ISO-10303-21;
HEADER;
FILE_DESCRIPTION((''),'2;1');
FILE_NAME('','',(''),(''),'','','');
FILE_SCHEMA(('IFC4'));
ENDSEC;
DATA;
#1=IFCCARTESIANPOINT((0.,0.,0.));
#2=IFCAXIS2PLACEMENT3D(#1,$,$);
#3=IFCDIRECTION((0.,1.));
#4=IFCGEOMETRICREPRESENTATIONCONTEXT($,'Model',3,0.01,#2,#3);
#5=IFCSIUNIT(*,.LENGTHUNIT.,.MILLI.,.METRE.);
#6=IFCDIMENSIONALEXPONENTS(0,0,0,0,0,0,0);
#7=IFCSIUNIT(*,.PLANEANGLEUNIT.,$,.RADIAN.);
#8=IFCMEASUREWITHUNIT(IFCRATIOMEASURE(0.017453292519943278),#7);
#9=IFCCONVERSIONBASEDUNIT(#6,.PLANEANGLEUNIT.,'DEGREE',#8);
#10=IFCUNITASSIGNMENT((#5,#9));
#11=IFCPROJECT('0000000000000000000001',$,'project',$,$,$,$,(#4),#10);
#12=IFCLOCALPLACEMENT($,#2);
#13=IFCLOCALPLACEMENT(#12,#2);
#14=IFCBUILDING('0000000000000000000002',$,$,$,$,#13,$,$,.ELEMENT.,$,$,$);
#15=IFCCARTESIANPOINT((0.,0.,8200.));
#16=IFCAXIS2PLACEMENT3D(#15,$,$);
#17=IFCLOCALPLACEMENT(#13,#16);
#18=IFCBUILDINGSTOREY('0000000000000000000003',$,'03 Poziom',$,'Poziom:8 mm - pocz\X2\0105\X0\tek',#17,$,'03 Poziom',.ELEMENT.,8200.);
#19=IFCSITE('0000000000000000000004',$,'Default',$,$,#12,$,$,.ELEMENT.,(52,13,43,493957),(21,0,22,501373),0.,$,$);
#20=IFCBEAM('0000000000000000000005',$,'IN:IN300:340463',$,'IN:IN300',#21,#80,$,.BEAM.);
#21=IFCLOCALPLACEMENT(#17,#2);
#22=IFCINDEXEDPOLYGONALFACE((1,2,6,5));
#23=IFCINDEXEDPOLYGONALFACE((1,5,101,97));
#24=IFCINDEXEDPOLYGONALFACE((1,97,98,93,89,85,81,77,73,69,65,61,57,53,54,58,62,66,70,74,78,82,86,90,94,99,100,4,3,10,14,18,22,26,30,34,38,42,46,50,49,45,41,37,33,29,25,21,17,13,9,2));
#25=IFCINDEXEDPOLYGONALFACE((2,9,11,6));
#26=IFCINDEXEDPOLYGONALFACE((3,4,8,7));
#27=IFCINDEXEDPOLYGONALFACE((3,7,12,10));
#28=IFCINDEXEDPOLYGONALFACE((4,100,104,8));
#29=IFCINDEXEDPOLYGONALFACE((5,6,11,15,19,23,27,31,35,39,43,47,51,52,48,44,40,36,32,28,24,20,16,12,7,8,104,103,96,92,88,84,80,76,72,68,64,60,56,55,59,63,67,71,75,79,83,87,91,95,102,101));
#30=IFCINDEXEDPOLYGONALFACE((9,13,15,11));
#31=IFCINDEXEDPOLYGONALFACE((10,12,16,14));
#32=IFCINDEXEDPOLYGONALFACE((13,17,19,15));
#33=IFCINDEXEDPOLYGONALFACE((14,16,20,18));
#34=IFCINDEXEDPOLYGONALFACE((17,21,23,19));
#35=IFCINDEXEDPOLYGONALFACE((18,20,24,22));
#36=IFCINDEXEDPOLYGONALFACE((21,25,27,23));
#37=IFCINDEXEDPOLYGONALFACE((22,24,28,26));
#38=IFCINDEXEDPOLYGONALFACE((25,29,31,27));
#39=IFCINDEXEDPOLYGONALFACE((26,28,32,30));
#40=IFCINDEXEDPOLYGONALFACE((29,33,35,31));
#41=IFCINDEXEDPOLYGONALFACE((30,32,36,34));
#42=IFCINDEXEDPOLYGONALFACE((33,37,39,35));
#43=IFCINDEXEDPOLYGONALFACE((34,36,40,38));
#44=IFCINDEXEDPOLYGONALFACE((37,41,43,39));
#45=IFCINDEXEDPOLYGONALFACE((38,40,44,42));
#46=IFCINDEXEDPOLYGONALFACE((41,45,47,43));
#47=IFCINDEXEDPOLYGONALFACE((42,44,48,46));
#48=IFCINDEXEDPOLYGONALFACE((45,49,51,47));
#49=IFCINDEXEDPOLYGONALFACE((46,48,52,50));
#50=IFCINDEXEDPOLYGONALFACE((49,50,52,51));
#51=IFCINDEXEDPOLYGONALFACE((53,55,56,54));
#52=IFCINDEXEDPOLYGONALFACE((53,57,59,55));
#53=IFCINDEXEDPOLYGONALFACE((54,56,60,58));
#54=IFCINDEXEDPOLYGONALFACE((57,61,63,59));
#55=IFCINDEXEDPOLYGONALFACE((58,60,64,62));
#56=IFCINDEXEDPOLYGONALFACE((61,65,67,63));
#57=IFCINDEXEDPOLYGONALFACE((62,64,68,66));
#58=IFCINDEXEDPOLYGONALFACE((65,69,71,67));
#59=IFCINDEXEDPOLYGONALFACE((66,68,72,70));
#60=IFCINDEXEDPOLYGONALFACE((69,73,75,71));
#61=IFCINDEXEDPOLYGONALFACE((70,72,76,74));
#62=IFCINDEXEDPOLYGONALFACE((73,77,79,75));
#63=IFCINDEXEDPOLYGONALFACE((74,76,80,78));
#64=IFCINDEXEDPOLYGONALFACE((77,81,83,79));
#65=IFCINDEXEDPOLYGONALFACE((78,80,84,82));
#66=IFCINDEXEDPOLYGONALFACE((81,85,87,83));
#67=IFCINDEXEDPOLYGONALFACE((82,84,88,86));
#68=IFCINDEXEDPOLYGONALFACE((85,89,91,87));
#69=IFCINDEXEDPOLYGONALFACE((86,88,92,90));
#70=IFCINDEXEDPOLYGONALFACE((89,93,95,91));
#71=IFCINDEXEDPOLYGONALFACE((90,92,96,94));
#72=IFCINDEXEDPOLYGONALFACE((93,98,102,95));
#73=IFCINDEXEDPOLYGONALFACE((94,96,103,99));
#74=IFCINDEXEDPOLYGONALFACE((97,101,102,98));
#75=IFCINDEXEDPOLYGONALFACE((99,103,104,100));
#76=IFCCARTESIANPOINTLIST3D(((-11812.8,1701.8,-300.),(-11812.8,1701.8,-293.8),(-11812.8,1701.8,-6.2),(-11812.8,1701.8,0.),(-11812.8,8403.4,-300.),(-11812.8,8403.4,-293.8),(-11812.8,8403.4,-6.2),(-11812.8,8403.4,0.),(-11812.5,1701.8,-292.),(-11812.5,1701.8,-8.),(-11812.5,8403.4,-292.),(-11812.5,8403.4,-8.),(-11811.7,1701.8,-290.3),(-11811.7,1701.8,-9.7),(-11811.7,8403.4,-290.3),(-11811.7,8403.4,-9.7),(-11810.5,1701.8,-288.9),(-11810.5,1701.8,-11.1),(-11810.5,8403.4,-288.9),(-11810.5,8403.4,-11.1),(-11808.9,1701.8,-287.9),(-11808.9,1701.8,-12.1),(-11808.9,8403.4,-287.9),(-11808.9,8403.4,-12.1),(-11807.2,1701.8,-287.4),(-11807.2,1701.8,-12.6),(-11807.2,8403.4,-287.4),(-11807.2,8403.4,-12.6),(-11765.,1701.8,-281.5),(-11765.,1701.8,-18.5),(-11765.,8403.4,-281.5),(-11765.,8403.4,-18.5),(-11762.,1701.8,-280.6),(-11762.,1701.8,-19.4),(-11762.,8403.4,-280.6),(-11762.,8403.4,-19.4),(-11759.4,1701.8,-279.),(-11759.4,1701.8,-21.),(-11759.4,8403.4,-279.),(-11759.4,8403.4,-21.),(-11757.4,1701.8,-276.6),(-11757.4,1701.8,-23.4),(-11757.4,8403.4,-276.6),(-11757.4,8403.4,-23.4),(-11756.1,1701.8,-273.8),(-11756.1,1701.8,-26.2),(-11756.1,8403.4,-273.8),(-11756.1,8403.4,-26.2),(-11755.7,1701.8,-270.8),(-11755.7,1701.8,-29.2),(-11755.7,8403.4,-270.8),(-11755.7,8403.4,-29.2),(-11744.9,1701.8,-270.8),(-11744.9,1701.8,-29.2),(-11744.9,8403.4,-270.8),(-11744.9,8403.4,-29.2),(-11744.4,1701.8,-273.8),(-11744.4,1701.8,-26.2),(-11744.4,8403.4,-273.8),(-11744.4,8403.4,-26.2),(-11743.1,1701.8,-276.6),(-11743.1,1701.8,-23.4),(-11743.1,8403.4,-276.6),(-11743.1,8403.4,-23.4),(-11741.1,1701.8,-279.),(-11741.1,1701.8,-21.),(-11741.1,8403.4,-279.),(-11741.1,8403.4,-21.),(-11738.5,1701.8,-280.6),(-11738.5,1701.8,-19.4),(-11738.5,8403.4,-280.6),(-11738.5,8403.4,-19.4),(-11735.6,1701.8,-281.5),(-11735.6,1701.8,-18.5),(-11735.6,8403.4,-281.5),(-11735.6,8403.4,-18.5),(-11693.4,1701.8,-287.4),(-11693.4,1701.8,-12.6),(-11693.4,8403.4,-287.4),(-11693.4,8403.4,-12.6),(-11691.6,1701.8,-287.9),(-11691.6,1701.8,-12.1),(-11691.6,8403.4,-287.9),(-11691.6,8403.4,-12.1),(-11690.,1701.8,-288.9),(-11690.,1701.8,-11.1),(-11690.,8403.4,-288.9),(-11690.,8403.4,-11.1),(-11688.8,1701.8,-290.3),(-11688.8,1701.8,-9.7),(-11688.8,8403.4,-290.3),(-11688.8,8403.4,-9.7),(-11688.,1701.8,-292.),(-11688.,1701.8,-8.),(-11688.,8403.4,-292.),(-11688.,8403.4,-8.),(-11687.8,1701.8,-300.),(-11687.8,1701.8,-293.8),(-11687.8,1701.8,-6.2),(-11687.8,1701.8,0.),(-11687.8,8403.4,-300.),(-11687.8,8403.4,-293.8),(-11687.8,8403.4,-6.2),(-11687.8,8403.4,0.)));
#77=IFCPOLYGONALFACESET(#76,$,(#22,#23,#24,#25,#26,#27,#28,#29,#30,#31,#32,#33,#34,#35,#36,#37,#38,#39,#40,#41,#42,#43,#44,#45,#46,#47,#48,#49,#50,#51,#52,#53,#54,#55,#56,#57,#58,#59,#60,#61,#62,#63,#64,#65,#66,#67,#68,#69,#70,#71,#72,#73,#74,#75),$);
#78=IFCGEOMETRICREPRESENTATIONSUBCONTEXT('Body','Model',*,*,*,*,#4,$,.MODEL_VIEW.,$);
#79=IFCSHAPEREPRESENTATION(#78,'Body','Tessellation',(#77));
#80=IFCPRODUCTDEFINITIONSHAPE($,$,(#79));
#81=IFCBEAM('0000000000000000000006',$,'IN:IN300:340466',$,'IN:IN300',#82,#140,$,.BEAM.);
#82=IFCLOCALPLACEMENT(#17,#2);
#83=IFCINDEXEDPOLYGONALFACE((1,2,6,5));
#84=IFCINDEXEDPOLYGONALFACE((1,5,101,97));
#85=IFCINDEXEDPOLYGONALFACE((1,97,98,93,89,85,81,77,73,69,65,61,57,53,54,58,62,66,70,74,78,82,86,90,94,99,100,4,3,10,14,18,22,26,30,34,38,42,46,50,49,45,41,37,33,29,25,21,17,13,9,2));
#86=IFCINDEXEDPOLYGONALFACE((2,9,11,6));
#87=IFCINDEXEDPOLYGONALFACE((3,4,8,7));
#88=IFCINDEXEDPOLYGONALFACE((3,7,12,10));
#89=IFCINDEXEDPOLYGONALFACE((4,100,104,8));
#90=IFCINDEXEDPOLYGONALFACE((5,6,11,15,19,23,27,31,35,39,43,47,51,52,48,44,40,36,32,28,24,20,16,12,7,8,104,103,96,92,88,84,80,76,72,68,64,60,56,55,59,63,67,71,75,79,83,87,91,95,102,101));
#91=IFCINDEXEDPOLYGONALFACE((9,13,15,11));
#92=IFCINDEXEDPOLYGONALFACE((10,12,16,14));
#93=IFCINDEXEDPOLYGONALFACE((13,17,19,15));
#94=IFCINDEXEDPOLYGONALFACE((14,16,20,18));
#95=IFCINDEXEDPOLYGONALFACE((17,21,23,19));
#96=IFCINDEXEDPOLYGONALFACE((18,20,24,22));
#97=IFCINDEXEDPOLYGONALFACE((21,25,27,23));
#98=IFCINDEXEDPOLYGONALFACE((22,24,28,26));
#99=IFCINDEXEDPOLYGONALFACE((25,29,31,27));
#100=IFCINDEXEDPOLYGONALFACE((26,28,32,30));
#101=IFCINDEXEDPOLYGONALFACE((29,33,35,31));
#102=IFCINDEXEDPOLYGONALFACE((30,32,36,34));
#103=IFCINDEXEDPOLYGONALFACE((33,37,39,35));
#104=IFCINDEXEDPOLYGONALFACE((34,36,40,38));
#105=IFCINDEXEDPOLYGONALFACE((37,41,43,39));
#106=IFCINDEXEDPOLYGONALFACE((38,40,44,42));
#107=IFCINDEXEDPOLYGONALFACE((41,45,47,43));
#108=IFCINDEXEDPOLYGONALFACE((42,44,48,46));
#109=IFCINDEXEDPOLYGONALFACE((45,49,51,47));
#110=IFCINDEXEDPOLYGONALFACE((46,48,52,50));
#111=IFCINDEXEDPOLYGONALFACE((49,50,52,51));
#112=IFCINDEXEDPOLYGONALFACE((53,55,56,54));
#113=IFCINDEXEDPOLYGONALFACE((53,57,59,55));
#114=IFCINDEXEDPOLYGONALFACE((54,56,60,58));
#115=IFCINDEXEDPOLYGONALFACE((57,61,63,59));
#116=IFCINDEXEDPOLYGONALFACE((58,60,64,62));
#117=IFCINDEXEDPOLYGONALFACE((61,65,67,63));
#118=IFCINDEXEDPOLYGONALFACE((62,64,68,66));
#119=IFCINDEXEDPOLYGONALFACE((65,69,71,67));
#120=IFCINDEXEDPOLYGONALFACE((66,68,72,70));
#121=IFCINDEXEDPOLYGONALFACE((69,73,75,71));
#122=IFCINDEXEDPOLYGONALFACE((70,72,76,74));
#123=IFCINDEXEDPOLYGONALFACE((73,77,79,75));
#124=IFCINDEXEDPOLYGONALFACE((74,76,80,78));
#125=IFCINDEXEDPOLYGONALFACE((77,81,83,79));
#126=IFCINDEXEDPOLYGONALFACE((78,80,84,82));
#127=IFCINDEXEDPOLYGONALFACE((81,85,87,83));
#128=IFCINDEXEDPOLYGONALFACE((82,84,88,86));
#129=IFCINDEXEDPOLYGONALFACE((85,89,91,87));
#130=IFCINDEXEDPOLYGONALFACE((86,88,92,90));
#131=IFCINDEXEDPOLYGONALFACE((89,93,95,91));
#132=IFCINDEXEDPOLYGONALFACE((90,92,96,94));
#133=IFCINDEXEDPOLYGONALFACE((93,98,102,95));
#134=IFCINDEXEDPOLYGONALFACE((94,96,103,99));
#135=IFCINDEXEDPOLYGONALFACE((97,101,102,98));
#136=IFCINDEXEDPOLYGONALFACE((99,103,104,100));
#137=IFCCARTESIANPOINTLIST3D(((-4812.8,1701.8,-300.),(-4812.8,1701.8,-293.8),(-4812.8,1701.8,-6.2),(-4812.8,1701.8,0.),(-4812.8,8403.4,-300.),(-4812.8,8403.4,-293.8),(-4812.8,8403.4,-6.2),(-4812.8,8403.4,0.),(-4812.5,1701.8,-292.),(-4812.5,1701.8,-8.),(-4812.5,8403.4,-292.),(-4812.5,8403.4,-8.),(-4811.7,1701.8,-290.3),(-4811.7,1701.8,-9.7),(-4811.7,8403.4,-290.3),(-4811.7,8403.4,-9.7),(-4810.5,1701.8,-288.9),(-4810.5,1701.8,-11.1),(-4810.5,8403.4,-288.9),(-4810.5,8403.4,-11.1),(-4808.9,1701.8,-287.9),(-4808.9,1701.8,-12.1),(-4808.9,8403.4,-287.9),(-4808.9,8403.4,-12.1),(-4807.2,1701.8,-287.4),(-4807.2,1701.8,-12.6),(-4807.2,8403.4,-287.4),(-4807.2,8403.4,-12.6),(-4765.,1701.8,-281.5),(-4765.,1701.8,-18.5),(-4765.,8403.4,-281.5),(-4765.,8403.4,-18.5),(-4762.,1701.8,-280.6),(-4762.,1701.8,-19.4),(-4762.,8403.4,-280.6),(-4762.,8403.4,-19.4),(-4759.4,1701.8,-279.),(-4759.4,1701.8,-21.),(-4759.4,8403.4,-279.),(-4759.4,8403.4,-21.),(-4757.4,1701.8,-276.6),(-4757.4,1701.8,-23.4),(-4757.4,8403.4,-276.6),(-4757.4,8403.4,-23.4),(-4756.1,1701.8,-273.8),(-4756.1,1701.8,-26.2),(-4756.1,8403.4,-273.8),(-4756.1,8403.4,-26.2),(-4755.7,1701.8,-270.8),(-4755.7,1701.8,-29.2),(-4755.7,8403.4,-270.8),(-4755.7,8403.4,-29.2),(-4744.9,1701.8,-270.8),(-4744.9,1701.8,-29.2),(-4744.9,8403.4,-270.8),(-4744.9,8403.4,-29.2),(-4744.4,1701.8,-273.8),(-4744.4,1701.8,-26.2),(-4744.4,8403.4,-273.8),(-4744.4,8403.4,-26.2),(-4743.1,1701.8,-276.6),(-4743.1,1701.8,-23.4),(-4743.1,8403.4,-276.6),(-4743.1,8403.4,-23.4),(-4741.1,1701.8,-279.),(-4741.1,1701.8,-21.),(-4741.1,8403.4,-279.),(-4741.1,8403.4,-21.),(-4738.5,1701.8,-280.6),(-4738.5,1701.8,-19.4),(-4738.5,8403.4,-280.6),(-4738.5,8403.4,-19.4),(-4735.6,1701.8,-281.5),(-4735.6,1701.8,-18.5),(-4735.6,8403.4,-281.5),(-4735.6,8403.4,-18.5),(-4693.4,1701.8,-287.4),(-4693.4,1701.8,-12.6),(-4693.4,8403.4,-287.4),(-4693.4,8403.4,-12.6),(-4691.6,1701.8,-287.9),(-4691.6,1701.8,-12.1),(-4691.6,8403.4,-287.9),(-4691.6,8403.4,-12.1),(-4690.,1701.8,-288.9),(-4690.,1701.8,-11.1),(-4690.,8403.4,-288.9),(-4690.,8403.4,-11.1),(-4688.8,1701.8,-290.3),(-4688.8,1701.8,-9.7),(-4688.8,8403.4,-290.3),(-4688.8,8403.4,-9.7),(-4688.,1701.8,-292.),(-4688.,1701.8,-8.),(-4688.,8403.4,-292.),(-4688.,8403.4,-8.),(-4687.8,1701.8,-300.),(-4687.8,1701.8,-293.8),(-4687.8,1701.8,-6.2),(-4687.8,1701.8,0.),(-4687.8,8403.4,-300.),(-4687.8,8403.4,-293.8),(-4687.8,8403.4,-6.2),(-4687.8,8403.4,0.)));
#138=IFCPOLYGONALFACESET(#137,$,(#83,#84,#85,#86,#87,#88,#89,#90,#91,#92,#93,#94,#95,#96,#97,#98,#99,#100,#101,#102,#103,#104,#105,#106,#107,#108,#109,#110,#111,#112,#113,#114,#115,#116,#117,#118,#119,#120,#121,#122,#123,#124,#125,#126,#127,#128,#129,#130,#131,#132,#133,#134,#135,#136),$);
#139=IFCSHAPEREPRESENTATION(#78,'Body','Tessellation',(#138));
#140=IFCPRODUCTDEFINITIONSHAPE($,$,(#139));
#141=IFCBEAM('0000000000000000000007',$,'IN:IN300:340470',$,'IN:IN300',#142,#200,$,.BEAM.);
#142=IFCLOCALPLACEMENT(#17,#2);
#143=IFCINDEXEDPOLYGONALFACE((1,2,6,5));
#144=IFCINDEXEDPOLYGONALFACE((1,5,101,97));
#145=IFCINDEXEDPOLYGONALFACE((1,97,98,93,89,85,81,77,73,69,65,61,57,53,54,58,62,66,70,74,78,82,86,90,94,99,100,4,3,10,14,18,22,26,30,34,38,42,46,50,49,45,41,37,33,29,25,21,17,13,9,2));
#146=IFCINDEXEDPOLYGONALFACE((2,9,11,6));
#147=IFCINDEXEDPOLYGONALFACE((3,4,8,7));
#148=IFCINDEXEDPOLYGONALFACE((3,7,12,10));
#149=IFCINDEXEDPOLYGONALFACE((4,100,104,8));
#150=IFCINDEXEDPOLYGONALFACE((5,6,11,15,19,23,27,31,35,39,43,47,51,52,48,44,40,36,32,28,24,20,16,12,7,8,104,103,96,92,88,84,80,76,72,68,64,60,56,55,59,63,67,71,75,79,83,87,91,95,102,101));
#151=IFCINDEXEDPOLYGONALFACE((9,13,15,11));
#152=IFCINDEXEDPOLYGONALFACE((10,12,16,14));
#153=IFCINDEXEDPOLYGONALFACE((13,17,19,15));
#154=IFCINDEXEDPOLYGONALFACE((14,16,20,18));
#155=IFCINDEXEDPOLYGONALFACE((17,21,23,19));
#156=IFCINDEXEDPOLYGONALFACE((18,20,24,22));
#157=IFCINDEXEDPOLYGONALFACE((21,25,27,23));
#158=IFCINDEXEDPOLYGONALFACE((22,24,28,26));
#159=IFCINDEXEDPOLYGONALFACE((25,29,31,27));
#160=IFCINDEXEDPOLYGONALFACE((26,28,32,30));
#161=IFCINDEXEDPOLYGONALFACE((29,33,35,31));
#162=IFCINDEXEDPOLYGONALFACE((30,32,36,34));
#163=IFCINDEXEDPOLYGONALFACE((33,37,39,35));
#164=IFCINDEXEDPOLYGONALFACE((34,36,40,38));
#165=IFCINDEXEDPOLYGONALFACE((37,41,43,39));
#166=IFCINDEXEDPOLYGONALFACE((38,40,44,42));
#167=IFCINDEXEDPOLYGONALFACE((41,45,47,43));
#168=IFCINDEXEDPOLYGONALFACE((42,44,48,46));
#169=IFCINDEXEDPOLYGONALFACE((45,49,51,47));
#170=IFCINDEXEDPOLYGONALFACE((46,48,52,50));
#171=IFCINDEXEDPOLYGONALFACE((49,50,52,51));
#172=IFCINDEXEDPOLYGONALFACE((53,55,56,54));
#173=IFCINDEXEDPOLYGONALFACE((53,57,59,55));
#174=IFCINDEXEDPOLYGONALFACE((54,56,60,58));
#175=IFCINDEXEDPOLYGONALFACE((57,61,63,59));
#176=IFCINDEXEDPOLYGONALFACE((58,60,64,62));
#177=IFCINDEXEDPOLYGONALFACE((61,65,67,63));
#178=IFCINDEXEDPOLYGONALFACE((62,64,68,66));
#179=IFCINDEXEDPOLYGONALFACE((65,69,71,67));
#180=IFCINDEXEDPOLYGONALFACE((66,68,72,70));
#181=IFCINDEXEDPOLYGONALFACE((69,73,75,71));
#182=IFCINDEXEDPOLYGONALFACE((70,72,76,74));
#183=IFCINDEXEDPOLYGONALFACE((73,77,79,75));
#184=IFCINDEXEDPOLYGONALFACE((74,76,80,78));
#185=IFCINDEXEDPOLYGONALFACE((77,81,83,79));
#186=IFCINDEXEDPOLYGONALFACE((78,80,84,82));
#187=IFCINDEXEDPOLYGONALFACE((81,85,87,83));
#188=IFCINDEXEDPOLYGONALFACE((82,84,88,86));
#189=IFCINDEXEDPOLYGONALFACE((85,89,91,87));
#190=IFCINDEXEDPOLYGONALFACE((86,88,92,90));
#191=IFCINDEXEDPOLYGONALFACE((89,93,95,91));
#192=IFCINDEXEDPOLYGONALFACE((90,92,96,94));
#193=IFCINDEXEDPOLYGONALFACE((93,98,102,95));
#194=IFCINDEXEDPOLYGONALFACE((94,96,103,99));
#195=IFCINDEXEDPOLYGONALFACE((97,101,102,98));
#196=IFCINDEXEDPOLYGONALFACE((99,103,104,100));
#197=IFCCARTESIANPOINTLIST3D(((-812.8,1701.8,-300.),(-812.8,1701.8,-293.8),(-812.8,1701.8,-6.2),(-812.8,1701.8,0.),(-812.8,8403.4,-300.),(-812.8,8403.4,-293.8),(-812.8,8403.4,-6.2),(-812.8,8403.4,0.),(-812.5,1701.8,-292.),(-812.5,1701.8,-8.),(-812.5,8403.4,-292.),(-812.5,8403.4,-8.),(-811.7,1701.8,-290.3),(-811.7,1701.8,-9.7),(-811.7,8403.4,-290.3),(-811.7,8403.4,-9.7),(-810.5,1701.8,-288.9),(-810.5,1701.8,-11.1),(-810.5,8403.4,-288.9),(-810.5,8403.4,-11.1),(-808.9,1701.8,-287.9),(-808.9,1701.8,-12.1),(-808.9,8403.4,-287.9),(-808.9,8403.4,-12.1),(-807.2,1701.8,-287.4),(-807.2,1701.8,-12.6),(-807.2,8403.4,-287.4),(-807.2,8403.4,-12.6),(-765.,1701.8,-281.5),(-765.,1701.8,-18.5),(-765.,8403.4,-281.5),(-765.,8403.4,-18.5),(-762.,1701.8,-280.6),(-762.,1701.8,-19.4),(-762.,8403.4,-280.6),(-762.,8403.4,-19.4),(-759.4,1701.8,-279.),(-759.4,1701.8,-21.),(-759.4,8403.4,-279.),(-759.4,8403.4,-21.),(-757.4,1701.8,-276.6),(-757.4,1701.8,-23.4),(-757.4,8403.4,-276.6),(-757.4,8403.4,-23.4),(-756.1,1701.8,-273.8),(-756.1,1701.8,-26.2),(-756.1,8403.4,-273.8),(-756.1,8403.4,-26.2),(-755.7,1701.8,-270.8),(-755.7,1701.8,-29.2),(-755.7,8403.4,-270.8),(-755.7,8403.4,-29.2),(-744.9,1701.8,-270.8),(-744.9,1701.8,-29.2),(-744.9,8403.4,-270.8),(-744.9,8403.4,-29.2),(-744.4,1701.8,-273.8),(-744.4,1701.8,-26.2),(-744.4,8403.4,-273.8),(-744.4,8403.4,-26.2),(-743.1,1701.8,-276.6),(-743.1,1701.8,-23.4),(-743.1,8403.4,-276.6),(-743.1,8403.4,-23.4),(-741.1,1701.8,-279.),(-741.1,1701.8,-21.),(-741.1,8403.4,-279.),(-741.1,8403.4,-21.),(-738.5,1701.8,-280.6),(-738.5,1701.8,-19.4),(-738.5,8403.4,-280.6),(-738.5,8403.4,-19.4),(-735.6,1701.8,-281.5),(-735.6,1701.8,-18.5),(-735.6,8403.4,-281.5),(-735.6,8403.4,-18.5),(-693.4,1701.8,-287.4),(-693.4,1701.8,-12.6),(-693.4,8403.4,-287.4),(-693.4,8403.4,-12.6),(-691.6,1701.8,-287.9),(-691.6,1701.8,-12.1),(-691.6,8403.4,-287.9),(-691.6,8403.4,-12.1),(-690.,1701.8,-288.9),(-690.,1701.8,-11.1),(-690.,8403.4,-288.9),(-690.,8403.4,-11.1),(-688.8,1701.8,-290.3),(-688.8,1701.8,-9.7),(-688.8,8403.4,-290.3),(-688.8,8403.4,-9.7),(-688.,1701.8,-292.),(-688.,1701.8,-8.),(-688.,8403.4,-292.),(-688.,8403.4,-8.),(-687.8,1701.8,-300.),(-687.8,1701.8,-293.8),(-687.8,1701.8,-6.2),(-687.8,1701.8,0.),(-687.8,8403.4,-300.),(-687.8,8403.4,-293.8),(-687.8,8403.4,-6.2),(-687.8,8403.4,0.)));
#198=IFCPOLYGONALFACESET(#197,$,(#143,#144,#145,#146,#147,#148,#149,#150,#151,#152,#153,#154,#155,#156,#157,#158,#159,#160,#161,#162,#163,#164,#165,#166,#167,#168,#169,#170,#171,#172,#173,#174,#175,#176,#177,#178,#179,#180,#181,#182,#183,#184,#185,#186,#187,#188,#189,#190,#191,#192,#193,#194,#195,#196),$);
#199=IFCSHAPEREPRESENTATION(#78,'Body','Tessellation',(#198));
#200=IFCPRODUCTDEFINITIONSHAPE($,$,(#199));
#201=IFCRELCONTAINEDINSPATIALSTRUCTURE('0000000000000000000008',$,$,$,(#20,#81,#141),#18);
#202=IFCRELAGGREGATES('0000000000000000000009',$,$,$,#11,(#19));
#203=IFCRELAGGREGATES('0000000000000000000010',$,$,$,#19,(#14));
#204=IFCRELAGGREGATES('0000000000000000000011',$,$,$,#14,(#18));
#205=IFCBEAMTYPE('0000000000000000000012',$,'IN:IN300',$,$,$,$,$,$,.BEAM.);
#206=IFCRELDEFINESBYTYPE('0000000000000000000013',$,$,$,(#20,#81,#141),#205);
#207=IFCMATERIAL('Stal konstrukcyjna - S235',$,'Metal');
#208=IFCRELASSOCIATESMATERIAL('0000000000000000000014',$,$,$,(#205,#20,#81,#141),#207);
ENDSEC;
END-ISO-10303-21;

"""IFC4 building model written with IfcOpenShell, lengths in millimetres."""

from ifc_helpers import new_model, entity, si_unit, converted_unit, direction, frame, origin, place, context, subcontext, project, spatial, line, arc, indexed_curve, outline, extrude, source, transform, mapped, material, type_object, type_shapes, element, save


model = new_model("IFC4")

# Units and contexts
model_context = context("Model", 3, precision=0.01, world=origin(), true_north=direction((0.0, 1.0)))
body_context = subcontext(model_context, "Body", "Model", "MODEL_VIEW")
ifc_project = project(units=[si_unit("LENGTHUNIT", "METRE", prefix="MILLI"), converted_unit("PLANEANGLEUNIT", "DEGREE", entity("IfcRatioMeasure", 0.017453292519943278), si_unit("PLANEANGLEUNIT", "RADIAN"), dimensions=[0, 0, 0, 0, 0, 0, 0])], contexts=[model_context])

# Site, building, storey
site_placement = place(None, origin())
site = spatial("IfcSite", under=ifc_project, at=site_placement, Name="Default", CompositionType="ELEMENT", RefLatitude=(52, 13, 43, 493957), RefLongitude=(21, 0, 22, 501373), RefElevation=0.0)
building_placement = place(site_placement, origin())
building = spatial("IfcBuilding", under=site, at=building_placement, CompositionType="ELEMENT")
storey_placement = place(building_placement, frame((0.0, 0.0, 8200.0)))
storey = spatial("IfcBuildingStorey", under=building, at=storey_placement, Name="03 Poziom", ObjectType="Poziom:8 mm - początek", LongName="03 Poziom", CompositionType="ELEMENT", Elevation=8200.0)

# Shared definitions
ifc_material_1 = material(Name="Stal konstrukcyjna - S235", Category="Metal")

# Beams
beam_type_1 = type_object("IfcBeamType", Name="IN:IN300", PredefinedType="BEAM", material=ifc_material_1)
shared_shape_1 = source(origin(), body_context, "Body", "SweptSolid", [
    extrude(outline(indexed_curve([(143.8, -62.5), (150.0, -62.5), (150.0, 62.5), (143.8, 62.5), (139.6, 60.9), (137.4, 56.9), (131.5, 14.7), (127.9, 8.1), (120.8, 5.4), (-120.8, 5.4), (-127.9, 8.1), (-131.5, 14.7), (-137.4, 56.9), (-139.6, 60.9), (-143.8, 62.5), (-150.0, 62.5), (-150.0, -62.5), (-143.8, -62.5), (-139.6, -60.9), (-137.4, -56.9), (-131.5, -14.7), (-127.9, -8.1), (-120.8, -5.4), (120.8, -5.4), (127.9, -8.1), (131.5, -14.7), (137.4, -56.9), (139.6, -60.9)], segments=[line(1, 2, 3, 4), arc(4, 5, 6), line(6, 7), arc(7, 8, 9), line(9, 10), arc(10, 11, 12), line(12, 13), arc(13, 14, 15), line(15, 16, 17, 18), arc(18, 19, 20), line(20, 21), arc(21, 22, 23), line(23, 24), arc(24, 25, 26), line(26, 27), arc(27, 28, 1)], self_intersect=False)), frame((-3350.8, 0.0, 0.0), z_axis=(1.0, 0.0, 0.0), x_axis=(0.0, 0.0, -1.0)), (0.0, 0.0, 1.0), 6701.6),
])
type_shapes(beam_type_1, [shared_shape_1])
for number, where, z_axis, x_axis, name in (
    (1, (-11750.3, 5052.6, -150.0), (0.0, 0.0, 1.0), (0.0, -1.0, 0.0), "IN:IN300:340463"),
    (2, (-4750.3, 5052.6, -150.0), (0.0, 0.0, 1.0), (0.0, -1.0, 0.0), "IN:IN300:340466"),
    (3, (-750.3, 5052.6, -150.0), (0.0, 0.0, 1.0), (0.0, -1.0, 0.0), "IN:IN300:340470"),
):
    element("IfcBeam", number, at=place(storey_placement, frame(where, z_axis=z_axis, x_axis=x_axis)), inside=storey, type_object=beam_type_1, material=ifc_material_1, Name=name, ObjectType="IN:IN300", PredefinedType="BEAM", context=body_context, shape_type="MappedRepresentation", body=[
        mapped(shared_shape_1, transform((0.0, 0.0, 0.0), scale=1.0)),
    ])

save(model, "model.ifc")
